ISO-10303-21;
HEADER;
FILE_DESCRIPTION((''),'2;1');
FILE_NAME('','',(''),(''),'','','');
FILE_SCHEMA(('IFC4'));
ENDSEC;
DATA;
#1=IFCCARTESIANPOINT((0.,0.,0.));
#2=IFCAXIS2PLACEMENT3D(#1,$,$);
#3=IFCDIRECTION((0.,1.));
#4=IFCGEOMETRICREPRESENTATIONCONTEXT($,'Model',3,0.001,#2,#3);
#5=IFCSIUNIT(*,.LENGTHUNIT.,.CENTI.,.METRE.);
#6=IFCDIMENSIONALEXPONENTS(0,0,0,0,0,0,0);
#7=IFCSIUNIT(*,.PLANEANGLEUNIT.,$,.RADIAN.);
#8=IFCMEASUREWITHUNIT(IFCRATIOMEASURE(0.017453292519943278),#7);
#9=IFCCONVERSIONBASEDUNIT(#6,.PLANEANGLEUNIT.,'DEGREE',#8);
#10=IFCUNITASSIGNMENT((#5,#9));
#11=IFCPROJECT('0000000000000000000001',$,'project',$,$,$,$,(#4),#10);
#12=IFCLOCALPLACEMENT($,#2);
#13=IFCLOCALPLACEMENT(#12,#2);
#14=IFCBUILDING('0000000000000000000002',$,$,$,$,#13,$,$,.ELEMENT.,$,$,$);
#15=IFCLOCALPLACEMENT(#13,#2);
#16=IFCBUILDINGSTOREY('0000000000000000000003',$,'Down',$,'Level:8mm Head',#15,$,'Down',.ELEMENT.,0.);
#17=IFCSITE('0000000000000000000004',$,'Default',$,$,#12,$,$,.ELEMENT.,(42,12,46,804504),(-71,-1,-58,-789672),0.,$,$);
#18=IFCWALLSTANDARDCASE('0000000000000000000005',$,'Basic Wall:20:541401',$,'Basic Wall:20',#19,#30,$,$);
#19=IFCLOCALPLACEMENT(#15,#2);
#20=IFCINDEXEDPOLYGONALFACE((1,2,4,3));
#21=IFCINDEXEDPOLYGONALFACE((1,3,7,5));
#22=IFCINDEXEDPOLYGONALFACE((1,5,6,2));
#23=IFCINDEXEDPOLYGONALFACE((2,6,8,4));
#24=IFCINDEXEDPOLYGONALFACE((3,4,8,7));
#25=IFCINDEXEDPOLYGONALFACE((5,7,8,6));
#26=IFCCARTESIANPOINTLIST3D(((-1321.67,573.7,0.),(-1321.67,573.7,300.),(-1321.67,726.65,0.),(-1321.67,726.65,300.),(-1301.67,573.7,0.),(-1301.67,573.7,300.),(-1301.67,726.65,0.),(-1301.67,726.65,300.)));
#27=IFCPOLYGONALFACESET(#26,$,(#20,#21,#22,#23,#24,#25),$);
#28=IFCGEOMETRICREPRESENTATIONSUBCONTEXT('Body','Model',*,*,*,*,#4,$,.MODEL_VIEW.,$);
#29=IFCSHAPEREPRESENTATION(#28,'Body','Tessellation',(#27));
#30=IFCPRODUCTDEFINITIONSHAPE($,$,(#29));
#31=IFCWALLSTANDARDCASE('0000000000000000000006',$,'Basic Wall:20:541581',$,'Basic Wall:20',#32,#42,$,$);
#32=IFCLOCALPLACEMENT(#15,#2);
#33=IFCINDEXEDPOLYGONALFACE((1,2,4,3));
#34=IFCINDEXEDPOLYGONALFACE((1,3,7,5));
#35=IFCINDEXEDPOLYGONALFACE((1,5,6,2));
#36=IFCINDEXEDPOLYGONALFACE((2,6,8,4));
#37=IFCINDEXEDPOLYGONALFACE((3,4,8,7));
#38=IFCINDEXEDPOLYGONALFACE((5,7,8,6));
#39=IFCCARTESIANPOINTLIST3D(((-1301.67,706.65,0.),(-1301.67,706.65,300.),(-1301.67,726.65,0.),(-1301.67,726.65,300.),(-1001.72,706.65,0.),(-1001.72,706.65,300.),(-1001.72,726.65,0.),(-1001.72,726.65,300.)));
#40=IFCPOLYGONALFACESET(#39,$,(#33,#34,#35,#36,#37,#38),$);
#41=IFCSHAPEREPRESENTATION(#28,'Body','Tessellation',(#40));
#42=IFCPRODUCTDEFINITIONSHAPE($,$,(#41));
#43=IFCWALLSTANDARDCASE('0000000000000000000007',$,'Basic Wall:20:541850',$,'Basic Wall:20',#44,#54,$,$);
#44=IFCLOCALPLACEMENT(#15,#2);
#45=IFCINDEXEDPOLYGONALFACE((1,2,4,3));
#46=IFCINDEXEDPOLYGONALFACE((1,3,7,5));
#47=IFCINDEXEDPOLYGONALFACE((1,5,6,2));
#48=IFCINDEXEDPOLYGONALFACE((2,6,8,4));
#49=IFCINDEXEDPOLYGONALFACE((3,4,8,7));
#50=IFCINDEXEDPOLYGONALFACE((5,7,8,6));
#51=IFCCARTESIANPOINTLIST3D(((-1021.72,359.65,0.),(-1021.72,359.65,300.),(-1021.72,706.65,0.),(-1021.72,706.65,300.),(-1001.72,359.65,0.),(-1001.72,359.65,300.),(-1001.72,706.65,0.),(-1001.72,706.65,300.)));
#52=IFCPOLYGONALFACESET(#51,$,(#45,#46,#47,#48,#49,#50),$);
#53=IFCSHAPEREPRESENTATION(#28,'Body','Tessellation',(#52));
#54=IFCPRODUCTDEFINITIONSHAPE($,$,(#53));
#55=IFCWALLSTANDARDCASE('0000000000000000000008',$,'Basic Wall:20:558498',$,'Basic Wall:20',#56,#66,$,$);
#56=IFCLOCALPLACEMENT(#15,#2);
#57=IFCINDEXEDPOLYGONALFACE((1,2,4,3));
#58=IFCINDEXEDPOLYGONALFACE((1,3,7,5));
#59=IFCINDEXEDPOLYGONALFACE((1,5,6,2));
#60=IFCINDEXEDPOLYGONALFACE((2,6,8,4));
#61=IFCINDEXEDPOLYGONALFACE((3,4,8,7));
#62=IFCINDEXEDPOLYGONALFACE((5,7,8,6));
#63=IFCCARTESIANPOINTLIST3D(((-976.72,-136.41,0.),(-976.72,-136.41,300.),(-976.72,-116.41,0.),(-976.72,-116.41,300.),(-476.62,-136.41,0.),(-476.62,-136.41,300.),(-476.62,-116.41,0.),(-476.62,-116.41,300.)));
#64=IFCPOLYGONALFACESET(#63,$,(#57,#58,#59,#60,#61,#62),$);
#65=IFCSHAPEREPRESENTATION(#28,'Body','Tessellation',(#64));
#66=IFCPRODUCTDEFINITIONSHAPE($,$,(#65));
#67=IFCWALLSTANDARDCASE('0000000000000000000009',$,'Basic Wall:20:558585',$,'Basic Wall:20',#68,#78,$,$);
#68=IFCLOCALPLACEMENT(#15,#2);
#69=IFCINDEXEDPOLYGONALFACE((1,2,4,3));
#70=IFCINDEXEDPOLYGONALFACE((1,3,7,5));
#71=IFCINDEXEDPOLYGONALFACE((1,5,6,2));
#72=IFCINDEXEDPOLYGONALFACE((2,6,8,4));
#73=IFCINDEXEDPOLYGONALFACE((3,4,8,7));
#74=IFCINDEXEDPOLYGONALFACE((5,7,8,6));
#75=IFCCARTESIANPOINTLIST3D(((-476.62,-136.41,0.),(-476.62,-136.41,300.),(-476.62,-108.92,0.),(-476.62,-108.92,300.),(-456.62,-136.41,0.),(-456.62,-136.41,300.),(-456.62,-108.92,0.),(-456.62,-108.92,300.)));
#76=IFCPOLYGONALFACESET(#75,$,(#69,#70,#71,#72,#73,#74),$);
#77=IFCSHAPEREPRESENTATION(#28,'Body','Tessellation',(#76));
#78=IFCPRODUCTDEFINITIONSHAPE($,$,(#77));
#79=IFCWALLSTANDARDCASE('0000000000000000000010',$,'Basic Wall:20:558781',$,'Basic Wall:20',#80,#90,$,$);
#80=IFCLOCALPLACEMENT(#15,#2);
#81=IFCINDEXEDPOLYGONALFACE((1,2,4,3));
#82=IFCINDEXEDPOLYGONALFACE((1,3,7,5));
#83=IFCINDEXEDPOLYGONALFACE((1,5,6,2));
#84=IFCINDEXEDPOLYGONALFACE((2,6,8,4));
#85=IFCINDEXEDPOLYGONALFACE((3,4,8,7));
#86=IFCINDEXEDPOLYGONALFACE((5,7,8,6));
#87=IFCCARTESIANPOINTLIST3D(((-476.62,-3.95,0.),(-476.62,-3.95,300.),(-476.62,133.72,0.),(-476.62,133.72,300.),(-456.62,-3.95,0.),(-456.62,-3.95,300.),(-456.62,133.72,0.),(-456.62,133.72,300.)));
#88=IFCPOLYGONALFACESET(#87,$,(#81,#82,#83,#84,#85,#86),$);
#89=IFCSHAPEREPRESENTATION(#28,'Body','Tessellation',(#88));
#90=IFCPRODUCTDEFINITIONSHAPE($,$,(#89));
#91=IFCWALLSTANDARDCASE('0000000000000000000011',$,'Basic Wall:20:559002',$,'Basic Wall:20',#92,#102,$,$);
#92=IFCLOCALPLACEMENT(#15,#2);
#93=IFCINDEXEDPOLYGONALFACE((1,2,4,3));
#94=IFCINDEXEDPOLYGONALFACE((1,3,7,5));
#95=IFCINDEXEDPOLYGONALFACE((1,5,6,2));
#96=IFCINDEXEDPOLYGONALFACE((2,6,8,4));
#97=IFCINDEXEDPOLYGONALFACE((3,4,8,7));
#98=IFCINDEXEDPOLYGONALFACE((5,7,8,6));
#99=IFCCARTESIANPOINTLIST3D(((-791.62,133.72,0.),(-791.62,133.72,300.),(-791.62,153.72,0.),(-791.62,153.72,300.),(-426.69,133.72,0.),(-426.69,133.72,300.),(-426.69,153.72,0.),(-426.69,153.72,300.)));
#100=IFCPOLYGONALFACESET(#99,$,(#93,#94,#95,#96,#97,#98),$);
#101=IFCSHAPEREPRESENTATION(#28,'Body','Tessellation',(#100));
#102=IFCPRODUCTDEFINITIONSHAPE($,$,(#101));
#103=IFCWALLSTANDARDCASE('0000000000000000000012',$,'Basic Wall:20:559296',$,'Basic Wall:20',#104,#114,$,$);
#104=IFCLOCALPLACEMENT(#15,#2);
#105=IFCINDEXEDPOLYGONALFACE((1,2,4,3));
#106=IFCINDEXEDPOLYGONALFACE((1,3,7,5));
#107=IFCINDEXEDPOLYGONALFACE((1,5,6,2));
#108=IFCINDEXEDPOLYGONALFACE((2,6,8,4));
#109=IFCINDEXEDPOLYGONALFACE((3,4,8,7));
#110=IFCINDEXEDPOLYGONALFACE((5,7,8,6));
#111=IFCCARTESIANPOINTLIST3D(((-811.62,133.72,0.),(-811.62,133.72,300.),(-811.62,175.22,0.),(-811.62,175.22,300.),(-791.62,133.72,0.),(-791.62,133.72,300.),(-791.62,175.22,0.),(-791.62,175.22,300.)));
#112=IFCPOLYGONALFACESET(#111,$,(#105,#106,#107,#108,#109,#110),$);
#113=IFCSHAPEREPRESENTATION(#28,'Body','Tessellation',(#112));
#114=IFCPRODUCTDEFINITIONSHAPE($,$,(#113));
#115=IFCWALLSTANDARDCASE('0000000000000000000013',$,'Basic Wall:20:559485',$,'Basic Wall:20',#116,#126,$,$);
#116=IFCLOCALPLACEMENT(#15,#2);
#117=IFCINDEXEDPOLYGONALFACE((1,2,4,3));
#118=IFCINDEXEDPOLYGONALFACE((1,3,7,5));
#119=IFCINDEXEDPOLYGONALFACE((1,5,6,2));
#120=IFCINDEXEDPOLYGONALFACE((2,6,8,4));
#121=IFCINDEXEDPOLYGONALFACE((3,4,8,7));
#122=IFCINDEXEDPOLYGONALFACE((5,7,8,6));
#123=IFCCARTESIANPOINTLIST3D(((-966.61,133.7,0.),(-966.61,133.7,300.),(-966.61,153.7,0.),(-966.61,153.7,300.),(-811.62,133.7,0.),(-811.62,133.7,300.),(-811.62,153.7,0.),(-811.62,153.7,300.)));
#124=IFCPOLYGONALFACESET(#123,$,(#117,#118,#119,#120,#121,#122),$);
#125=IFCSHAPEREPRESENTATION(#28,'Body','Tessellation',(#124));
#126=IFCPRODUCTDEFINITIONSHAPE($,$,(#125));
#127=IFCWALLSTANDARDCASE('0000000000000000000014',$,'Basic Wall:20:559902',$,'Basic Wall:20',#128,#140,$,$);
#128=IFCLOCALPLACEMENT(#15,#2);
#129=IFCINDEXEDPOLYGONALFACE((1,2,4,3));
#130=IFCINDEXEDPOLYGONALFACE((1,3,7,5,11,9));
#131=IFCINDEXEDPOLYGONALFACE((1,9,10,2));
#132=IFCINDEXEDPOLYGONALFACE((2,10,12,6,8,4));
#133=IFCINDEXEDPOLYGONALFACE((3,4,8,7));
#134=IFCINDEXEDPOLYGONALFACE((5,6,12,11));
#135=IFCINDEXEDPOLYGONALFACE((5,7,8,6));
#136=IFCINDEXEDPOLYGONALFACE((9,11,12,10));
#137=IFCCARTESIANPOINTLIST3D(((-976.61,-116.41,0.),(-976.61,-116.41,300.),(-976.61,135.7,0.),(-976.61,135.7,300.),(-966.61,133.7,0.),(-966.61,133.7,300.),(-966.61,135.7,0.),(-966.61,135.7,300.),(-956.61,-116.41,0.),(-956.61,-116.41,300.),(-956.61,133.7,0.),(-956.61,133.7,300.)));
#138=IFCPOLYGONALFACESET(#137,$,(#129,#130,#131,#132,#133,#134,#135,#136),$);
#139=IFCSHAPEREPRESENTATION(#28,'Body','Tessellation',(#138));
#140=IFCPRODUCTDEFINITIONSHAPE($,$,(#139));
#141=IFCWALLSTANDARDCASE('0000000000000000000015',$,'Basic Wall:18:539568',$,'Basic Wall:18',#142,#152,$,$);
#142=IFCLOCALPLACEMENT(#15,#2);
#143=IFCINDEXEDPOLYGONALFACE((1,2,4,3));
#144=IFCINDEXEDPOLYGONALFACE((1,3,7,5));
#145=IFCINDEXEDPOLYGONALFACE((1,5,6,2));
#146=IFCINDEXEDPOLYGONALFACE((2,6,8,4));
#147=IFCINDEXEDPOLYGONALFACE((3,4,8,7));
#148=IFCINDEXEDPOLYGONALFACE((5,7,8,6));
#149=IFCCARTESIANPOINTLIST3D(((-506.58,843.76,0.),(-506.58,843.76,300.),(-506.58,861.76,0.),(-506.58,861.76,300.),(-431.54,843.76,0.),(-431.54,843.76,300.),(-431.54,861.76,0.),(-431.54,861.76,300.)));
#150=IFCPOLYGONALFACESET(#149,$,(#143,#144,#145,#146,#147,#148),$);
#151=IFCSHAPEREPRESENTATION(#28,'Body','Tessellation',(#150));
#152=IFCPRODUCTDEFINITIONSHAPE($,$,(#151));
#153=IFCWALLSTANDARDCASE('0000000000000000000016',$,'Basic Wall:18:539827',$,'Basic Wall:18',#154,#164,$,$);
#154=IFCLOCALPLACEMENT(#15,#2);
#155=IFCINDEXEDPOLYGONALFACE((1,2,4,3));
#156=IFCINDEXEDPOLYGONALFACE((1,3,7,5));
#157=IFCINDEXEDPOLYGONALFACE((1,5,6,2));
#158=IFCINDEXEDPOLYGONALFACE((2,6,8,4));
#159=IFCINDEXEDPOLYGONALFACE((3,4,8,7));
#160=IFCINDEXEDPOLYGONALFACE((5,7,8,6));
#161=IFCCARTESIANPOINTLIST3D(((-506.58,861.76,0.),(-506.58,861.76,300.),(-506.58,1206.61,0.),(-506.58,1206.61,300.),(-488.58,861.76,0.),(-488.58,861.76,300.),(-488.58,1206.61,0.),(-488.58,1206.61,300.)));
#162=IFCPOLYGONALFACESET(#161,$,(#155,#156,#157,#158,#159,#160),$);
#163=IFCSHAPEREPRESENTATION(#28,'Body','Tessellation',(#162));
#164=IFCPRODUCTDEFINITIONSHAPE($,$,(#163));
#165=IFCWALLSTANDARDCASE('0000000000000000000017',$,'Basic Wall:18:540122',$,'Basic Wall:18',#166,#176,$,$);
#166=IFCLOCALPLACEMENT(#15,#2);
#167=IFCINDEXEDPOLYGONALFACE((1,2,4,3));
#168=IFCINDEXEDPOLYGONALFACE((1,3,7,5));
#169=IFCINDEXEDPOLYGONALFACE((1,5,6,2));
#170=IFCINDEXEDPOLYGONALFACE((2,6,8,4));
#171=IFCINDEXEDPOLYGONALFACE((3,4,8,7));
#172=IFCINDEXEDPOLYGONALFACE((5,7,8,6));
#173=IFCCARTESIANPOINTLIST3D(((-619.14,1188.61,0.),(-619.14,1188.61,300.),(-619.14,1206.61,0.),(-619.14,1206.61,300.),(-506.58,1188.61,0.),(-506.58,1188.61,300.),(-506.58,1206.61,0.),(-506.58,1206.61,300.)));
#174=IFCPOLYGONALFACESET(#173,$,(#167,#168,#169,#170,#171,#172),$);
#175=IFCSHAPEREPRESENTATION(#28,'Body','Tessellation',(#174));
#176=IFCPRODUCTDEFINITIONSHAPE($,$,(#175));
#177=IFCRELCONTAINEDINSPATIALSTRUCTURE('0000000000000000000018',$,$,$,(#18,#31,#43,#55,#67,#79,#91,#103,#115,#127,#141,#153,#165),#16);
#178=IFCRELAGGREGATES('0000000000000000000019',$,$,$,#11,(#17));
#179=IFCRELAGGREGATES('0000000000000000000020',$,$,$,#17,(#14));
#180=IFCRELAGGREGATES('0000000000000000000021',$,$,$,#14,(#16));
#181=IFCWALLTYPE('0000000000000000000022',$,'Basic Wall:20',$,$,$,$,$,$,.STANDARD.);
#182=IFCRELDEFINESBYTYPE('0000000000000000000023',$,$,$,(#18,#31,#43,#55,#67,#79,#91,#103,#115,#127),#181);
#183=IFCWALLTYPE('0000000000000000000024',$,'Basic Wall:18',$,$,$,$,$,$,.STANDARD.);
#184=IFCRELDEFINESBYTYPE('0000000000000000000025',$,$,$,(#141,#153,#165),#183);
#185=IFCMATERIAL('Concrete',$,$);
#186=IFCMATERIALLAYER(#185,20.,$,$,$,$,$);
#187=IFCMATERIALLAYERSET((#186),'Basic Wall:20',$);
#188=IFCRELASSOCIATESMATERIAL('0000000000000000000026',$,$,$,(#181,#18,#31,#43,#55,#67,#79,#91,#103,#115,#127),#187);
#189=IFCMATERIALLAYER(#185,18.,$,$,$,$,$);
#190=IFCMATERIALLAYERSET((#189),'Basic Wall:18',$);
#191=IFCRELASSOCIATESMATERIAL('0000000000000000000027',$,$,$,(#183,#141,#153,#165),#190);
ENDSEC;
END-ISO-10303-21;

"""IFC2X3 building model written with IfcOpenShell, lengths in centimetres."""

from ifc_helpers import new_model, entity, si_unit, converted_unit, direction, frame, frame_2d, origin, place, context, subcontext, project, spatial, polyline, rectangle, outline, extrude, material, layer, layer_set, layer_usage, type_object, element, save


model = new_model("IFC2X3")

# Units and contexts
model_context = context("Model", 3, precision=0.001, world=origin(), true_north=direction((0.0, 1.0)))
body_context = subcontext(model_context, "Body", "Model", "MODEL_VIEW")
ifc_project = project(units=[si_unit("LENGTHUNIT", "METRE", prefix="CENTI"), converted_unit("PLANEANGLEUNIT", "DEGREE", entity("IfcRatioMeasure", 0.017453292519943278), si_unit("PLANEANGLEUNIT", "RADIAN"), dimensions=[0, 0, 0, 0, 0, 0, 0])], contexts=[model_context])

# Site, building, storey
site_placement = place(None, origin())
site = spatial("IfcSite", under=ifc_project, at=site_placement, Name="Default", CompositionType="ELEMENT", RefLatitude=(42, 12, 46, 804504), RefLongitude=(-71, -1, -58, -789672), RefElevation=0.0)
building_placement = place(site_placement, origin())
building = spatial("IfcBuilding", under=site, at=building_placement, CompositionType="ELEMENT")
storey_placement = place(building_placement, origin())
storey = spatial("IfcBuildingStorey", under=building, at=storey_placement, Name="Down", ObjectType="Level:8mm Head", LongName="Down", CompositionType="ELEMENT", Elevation=0.0)

# Walls
ifc_material = material(Name="Concrete")
ifc_layer_1 = layer(ifc_material, 20.0)
ifc_layer_set_1 = layer_set([ifc_layer_1], Name="Basic Wall:20")
ifc_layer_usage_1 = layer_usage(ifc_layer_set_1, "AXIS2", "POSITIVE", -10.0)
wall_type_1 = type_object("IfcWallType", Name="Basic Wall:20", PredefinedType="STANDARD", material=ifc_layer_set_1)
wall_1_placement = place(storey_placement, frame((-1311.67, 573.7, 0.0), z_axis=(0.0, 0.0, 1.0), x_axis=(0.0, 1.0, 0.0)))
element("IfcWallStandardCase", 1, at=wall_1_placement, inside=storey, type_object=wall_type_1, material=ifc_layer_usage_1, Name="Basic Wall:20:541401", ObjectType="Basic Wall:20", context=body_context, shape_type="SweptSolid", body=[
    extrude(rectangle(XDim=152.95, YDim=20.0, at=frame_2d((76.47, 0.0), x_axis=(-1.0, 0.0))), origin(), (0.0, 0.0, 1.0), 300.0),
])
ifc_layer_usage_2 = layer_usage(ifc_layer_set_1, "AXIS2", "NEGATIVE", 10.0)
wall_2_placement = place(storey_placement, frame((-1301.67, 716.65, 0.0)))
element("IfcWallStandardCase", 2, at=wall_2_placement, inside=storey, type_object=wall_type_1, material=ifc_layer_usage_2, Name="Basic Wall:20:541581", ObjectType="Basic Wall:20", context=body_context, shape_type="SweptSolid", body=[
    extrude(rectangle(XDim=299.95, YDim=20.0, at=frame_2d((149.98, 0.0), x_axis=(-1.0, 0.0))), origin(), (0.0, 0.0, 1.0), 300.0),
])
ifc_layer_usage_3 = layer_usage(ifc_layer_set_1, "AXIS2", "NEGATIVE", 10.0)
wall_3_placement = place(storey_placement, frame((-1011.72, 706.65, 0.0), z_axis=(0.0, 0.0, 1.0), x_axis=(0.0, -1.0, 0.0)))
element("IfcWallStandardCase", 3, at=wall_3_placement, inside=storey, type_object=wall_type_1, material=ifc_layer_usage_3, Name="Basic Wall:20:541850", ObjectType="Basic Wall:20", context=body_context, shape_type="SweptSolid", body=[
    extrude(rectangle(XDim=347.0, YDim=20.0, at=frame_2d((173.5, 0.0), x_axis=(-1.0, 0.0))), origin(), (0.0, 0.0, 1.0), 300.0),
])
ifc_layer_usage_4 = layer_usage(ifc_layer_set_1, "AXIS2", "POSITIVE", -10.0)
wall_4_placement = place(storey_placement, frame((-976.72, -126.41, 0.0)))
element("IfcWallStandardCase", 4, at=wall_4_placement, inside=storey, type_object=wall_type_1, material=ifc_layer_usage_4, Name="Basic Wall:20:558498", ObjectType="Basic Wall:20", context=body_context, shape_type="SweptSolid", body=[
    extrude(rectangle(XDim=500.1, YDim=20.0, at=frame_2d((250.05, 0.0), x_axis=(-1.0, 0.0))), origin(), (0.0, 0.0, 1.0), 300.0),
])
ifc_layer_usage_5 = layer_usage(ifc_layer_set_1, "AXIS2", "POSITIVE", -10.0)
wall_5_placement = place(storey_placement, frame((-466.62, -136.41, 0.0), z_axis=(0.0, 0.0, 1.0), x_axis=(0.0, 1.0, 0.0)))
element("IfcWallStandardCase", 5, at=wall_5_placement, inside=storey, type_object=wall_type_1, material=ifc_layer_usage_5, Name="Basic Wall:20:558585", ObjectType="Basic Wall:20", context=body_context, shape_type="SweptSolid", body=[
    extrude(rectangle(XDim=27.49, YDim=20.0, at=frame_2d((13.74, 0.0), x_axis=(-1.0, 0.0))), origin(), (0.0, 0.0, 1.0), 300.0),
])
ifc_layer_usage_6 = layer_usage(ifc_layer_set_1, "AXIS2", "POSITIVE", -10.0)
wall_6_placement = place(storey_placement, frame((-466.62, -3.95, 0.0), z_axis=(0.0, 0.0, 1.0), x_axis=(0.0, 1.0, 0.0)))
element("IfcWallStandardCase", 6, at=wall_6_placement, inside=storey, type_object=wall_type_1, material=ifc_layer_usage_6, Name="Basic Wall:20:558781", ObjectType="Basic Wall:20", context=body_context, shape_type="SweptSolid", body=[
    extrude(rectangle(XDim=137.67, YDim=20.0, at=frame_2d((68.83, 0.0), x_axis=(-1.0, 0.0))), origin(), (0.0, 0.0, 1.0), 300.0),
])
ifc_layer_usage_7 = layer_usage(ifc_layer_set_1, "AXIS2", "POSITIVE", -10.0)
wall_7_placement = place(storey_placement, frame((-426.69, 143.72, 0.0), z_axis=(0.0, 0.0, 1.0), x_axis=(-1.0, 0.0, 0.0)))
element("IfcWallStandardCase", 7, at=wall_7_placement, inside=storey, type_object=wall_type_1, material=ifc_layer_usage_7, Name="Basic Wall:20:559002", ObjectType="Basic Wall:20", context=body_context, shape_type="SweptSolid", body=[
    extrude(rectangle(XDim=364.93, YDim=20.0, at=frame_2d((182.47, 0.0), x_axis=(-1.0, 0.0))), origin(), (0.0, 0.0, 1.0), 300.0),
])
ifc_layer_usage_8 = layer_usage(ifc_layer_set_1, "AXIS2", "POSITIVE", -10.0)
wall_8_placement = place(storey_placement, frame((-801.62, 133.72, 0.0), z_axis=(0.0, 0.0, 1.0), x_axis=(0.0, 1.0, 0.0)))
element("IfcWallStandardCase", 8, at=wall_8_placement, inside=storey, type_object=wall_type_1, material=ifc_layer_usage_8, Name="Basic Wall:20:559296", ObjectType="Basic Wall:20", context=body_context, shape_type="SweptSolid", body=[
    extrude(rectangle(XDim=41.5, YDim=20.0, at=frame_2d((20.75, 0.0), x_axis=(-1.0, 0.0))), origin(), (0.0, 0.0, 1.0), 300.0),
])
ifc_layer_usage_9 = layer_usage(ifc_layer_set_1, "AXIS2", "NEGATIVE", 10.0)
wall_9_placement = place(storey_placement, frame((-811.62, 143.7, 0.0), z_axis=(0.0, 0.0, 1.0), x_axis=(-1.0, 0.0, 0.0)))
element("IfcWallStandardCase", 9, at=wall_9_placement, inside=storey, type_object=wall_type_1, material=ifc_layer_usage_9, Name="Basic Wall:20:559485", ObjectType="Basic Wall:20", context=body_context, shape_type="SweptSolid", body=[
    extrude(rectangle(XDim=154.99, YDim=20.0, at=frame_2d((77.5, 0.0), x_axis=(-1.0, 0.0))), origin(), (0.0, 0.0, 1.0), 300.0),
])
ifc_layer_usage_10 = layer_usage(ifc_layer_set_1, "AXIS2", "NEGATIVE", 10.0)
wall_10_placement = place(storey_placement, frame((-966.61, 135.7, 0.0), z_axis=(0.0, 0.0, 1.0), x_axis=(0.0, -1.0, 0.0)))
element("IfcWallStandardCase", 10, at=wall_10_placement, inside=storey, type_object=wall_type_1, material=ifc_layer_usage_10, Name="Basic Wall:20:559902", ObjectType="Basic Wall:20", context=body_context, shape_type="SweptSolid", body=[
    extrude(outline(polyline([(252.1, -10.0), (252.1, 10.0), (2.0, 10.0), (2.0, 0.0), (0.0, 0.0), (0.0, -10.0), (252.1, -10.0)])), origin(), (0.0, 0.0, 1.0), 300.0),
])
ifc_layer_2 = layer(ifc_material, 18.0)
ifc_layer_set_2 = layer_set([ifc_layer_2], Name="Basic Wall:18")
ifc_layer_usage_11 = layer_usage(ifc_layer_set_2, "AXIS2", "POSITIVE", -9.0)
wall_type_2 = type_object("IfcWallType", Name="Basic Wall:18", PredefinedType="STANDARD", material=ifc_layer_set_2)
wall_11_placement = place(storey_placement, frame((-431.54, 852.76, 0.0), z_axis=(0.0, 0.0, 1.0), x_axis=(-1.0, 0.0, 0.0)))
element("IfcWallStandardCase", 11, at=wall_11_placement, inside=storey, type_object=wall_type_2, material=ifc_layer_usage_11, Name="Basic Wall:18:539568", ObjectType="Basic Wall:18", context=body_context, shape_type="SweptSolid", body=[
    extrude(rectangle(XDim=75.04, YDim=18.0, at=frame_2d((37.52, 0.0), x_axis=(-1.0, 0.0))), origin(), (0.0, 0.0, 1.0), 300.0),
])
ifc_layer_usage_12 = layer_usage(ifc_layer_set_2, "AXIS2", "NEGATIVE", 9.0)
wall_12_placement = place(storey_placement, frame((-497.58, 861.76, 0.0), z_axis=(0.0, 0.0, 1.0), x_axis=(0.0, 1.0, 0.0)))
element("IfcWallStandardCase", 12, at=wall_12_placement, inside=storey, type_object=wall_type_2, material=ifc_layer_usage_12, Name="Basic Wall:18:539827", ObjectType="Basic Wall:18", context=body_context, shape_type="SweptSolid", body=[
    extrude(rectangle(XDim=344.85, YDim=18.0, at=frame_2d((172.42, 0.0), x_axis=(-1.0, 0.0))), origin(), (0.0, 0.0, 1.0), 300.0),
])
ifc_layer_usage_13 = layer_usage(ifc_layer_set_2, "AXIS2", "POSITIVE", -9.0)
wall_13_placement = place(storey_placement, frame((-506.58, 1197.61, 0.0), z_axis=(0.0, 0.0, 1.0), x_axis=(-1.0, 0.0, 0.0)))
element("IfcWallStandardCase", 13, at=wall_13_placement, inside=storey, type_object=wall_type_2, material=ifc_layer_usage_13, Name="Basic Wall:18:540122", ObjectType="Basic Wall:18", context=body_context, shape_type="SweptSolid", body=[
    extrude(rectangle(XDim=112.56, YDim=18.0, at=frame_2d((56.28, 0.0), x_axis=(-1.0, 0.0))), origin(), (0.0, 0.0, 1.0), 300.0),
])

save(model, "model.ifc")
